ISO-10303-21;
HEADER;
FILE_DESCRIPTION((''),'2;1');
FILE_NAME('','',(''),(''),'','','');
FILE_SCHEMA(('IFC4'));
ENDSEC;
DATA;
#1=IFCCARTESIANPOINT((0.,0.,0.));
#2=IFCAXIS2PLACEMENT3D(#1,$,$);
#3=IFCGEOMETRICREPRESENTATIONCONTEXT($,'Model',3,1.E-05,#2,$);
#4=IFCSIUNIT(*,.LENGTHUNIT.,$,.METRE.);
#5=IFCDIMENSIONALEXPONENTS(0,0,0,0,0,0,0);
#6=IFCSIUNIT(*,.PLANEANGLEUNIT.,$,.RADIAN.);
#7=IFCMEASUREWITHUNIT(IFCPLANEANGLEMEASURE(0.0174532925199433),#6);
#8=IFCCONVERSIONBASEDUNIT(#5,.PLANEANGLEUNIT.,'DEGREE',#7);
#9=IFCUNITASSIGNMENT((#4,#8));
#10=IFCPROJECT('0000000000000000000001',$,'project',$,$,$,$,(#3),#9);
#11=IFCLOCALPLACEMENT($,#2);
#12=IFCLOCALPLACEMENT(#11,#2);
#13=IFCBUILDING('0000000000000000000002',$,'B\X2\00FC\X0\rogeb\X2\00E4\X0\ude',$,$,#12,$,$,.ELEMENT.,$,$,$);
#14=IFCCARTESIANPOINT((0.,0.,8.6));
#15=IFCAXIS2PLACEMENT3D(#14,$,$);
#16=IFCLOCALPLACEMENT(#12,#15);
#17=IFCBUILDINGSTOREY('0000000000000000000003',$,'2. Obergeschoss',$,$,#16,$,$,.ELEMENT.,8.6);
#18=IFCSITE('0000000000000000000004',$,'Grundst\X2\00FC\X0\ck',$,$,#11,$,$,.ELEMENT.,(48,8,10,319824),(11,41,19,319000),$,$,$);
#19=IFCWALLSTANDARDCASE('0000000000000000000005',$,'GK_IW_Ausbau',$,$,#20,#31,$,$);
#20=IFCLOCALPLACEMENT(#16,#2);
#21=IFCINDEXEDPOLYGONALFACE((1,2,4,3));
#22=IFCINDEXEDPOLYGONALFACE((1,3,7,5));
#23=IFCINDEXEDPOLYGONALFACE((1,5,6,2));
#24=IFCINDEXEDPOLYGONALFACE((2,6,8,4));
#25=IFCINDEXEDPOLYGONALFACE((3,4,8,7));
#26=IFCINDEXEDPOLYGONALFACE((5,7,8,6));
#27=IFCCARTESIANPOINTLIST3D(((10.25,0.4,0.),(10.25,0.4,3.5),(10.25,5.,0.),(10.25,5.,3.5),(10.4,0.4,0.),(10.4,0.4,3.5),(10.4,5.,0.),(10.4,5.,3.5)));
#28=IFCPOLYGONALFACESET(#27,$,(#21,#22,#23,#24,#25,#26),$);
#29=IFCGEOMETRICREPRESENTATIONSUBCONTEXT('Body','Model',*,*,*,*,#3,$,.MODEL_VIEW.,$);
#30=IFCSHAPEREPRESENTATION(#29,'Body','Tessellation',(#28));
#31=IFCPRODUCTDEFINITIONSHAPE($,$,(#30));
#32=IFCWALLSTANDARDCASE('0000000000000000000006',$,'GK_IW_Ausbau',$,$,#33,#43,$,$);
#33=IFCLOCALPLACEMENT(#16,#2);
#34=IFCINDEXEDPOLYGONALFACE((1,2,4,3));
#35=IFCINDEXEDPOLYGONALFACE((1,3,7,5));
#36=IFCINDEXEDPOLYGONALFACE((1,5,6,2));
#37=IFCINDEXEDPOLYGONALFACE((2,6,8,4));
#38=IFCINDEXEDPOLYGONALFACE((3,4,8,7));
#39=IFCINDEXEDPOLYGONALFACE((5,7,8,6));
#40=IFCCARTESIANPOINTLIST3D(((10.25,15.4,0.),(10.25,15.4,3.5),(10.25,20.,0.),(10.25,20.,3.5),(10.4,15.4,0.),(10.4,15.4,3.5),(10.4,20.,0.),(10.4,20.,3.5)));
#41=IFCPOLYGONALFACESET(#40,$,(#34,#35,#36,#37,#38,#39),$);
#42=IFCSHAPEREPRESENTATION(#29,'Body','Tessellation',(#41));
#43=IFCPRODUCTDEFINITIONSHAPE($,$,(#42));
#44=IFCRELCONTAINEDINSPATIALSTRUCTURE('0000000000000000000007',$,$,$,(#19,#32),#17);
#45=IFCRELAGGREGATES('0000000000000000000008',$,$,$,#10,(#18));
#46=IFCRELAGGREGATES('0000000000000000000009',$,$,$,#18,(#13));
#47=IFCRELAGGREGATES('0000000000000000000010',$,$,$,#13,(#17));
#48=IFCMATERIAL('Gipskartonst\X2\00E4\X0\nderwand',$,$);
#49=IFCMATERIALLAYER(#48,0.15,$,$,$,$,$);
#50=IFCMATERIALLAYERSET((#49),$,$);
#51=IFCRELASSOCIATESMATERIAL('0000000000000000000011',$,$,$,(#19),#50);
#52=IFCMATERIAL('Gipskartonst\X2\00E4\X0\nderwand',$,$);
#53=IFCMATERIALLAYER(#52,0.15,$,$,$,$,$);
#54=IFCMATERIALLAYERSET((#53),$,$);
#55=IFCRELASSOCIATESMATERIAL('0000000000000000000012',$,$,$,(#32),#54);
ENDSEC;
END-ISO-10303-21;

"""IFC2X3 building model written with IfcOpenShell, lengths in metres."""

from ifc_helpers import new_model, entity, si_unit, converted_unit, frame, frame_2d, origin, origin_with_axes, place, context, subcontext, project, spatial, rectangle, extrude, material, layer, layer_set, layer_usage, element, save


model = new_model("IFC2X3")

# Units and contexts
model_context = context("Model", 3, precision=1e-05, world=origin())
body_context = subcontext(model_context, "Body", "Model", "MODEL_VIEW")
ifc_project = project(units=[si_unit("LENGTHUNIT", "METRE"), converted_unit("PLANEANGLEUNIT", "DEGREE", entity("IfcPlaneAngleMeasure", 0.0174532925199433), si_unit("PLANEANGLEUNIT", "RADIAN"), dimensions=[0, 0, 0, 0, 0, 0, 0])], contexts=[model_context])

# Site, building, storey
site_placement = place(None, origin())
site = spatial("IfcSite", under=ifc_project, at=site_placement, Name="Grundstück", CompositionType="ELEMENT", RefLatitude=(48, 8, 10, 319824), RefLongitude=(11, 41, 19, 319000))
building_placement = place(site_placement, origin())
building = spatial("IfcBuilding", under=site, at=building_placement, Name="Bürogebäude", CompositionType="ELEMENT")
storey_placement = place(building_placement, frame((0.0, 0.0, 8.6)))
storey = spatial("IfcBuildingStorey", under=building, at=storey_placement, Name="2. Obergeschoss", CompositionType="ELEMENT", Elevation=8.6)

# Walls
ifc_material_1 = material(Name="Gipskartonständerwand")
ifc_layer_1 = layer(ifc_material_1, 0.15)
ifc_layer_set_1 = layer_set([ifc_layer_1])
ifc_layer_usage_1 = layer_usage(ifc_layer_set_1, "AXIS2", "POSITIVE", -0.15)
wall_1_placement = place(storey_placement, frame((10.25, 5.0, 0.0), z_axis=(0.0, 0.0, 1.0), x_axis=(0.0, -1.0, 0.0)))
element("IfcWallStandardCase", 1, at=wall_1_placement, inside=storey, material=ifc_layer_usage_1, Name="GK_IW_Ausbau", context=body_context, shape_type="SweptSolid", body=[
    extrude(rectangle(XDim=4.6, YDim=0.15, at=frame_2d((2.3, 0.075), x_axis=(1.0, 0.0))), origin_with_axes(), (0.0, 0.0, 1.0), 3.5),
])
ifc_material_2 = material(Name="Gipskartonständerwand")
ifc_layer_2 = layer(ifc_material_2, 0.15)
ifc_layer_set_2 = layer_set([ifc_layer_2])
ifc_layer_usage_2 = layer_usage(ifc_layer_set_2, "AXIS2", "POSITIVE", -0.15)
wall_2_placement = place(storey_placement, frame((10.25, 20.0, 0.0), z_axis=(0.0, 0.0, 1.0), x_axis=(0.0, -1.0, 0.0)))
element("IfcWallStandardCase", 2, at=wall_2_placement, inside=storey, material=ifc_layer_usage_2, Name="GK_IW_Ausbau", context=body_context, shape_type="SweptSolid", body=[
    extrude(rectangle(XDim=4.6, YDim=0.15, at=frame_2d((2.3, 0.075), x_axis=(1.0, 0.0))), origin_with_axes(), (0.0, 0.0, 1.0), 3.5),
])

save(model, "model.ifc")
